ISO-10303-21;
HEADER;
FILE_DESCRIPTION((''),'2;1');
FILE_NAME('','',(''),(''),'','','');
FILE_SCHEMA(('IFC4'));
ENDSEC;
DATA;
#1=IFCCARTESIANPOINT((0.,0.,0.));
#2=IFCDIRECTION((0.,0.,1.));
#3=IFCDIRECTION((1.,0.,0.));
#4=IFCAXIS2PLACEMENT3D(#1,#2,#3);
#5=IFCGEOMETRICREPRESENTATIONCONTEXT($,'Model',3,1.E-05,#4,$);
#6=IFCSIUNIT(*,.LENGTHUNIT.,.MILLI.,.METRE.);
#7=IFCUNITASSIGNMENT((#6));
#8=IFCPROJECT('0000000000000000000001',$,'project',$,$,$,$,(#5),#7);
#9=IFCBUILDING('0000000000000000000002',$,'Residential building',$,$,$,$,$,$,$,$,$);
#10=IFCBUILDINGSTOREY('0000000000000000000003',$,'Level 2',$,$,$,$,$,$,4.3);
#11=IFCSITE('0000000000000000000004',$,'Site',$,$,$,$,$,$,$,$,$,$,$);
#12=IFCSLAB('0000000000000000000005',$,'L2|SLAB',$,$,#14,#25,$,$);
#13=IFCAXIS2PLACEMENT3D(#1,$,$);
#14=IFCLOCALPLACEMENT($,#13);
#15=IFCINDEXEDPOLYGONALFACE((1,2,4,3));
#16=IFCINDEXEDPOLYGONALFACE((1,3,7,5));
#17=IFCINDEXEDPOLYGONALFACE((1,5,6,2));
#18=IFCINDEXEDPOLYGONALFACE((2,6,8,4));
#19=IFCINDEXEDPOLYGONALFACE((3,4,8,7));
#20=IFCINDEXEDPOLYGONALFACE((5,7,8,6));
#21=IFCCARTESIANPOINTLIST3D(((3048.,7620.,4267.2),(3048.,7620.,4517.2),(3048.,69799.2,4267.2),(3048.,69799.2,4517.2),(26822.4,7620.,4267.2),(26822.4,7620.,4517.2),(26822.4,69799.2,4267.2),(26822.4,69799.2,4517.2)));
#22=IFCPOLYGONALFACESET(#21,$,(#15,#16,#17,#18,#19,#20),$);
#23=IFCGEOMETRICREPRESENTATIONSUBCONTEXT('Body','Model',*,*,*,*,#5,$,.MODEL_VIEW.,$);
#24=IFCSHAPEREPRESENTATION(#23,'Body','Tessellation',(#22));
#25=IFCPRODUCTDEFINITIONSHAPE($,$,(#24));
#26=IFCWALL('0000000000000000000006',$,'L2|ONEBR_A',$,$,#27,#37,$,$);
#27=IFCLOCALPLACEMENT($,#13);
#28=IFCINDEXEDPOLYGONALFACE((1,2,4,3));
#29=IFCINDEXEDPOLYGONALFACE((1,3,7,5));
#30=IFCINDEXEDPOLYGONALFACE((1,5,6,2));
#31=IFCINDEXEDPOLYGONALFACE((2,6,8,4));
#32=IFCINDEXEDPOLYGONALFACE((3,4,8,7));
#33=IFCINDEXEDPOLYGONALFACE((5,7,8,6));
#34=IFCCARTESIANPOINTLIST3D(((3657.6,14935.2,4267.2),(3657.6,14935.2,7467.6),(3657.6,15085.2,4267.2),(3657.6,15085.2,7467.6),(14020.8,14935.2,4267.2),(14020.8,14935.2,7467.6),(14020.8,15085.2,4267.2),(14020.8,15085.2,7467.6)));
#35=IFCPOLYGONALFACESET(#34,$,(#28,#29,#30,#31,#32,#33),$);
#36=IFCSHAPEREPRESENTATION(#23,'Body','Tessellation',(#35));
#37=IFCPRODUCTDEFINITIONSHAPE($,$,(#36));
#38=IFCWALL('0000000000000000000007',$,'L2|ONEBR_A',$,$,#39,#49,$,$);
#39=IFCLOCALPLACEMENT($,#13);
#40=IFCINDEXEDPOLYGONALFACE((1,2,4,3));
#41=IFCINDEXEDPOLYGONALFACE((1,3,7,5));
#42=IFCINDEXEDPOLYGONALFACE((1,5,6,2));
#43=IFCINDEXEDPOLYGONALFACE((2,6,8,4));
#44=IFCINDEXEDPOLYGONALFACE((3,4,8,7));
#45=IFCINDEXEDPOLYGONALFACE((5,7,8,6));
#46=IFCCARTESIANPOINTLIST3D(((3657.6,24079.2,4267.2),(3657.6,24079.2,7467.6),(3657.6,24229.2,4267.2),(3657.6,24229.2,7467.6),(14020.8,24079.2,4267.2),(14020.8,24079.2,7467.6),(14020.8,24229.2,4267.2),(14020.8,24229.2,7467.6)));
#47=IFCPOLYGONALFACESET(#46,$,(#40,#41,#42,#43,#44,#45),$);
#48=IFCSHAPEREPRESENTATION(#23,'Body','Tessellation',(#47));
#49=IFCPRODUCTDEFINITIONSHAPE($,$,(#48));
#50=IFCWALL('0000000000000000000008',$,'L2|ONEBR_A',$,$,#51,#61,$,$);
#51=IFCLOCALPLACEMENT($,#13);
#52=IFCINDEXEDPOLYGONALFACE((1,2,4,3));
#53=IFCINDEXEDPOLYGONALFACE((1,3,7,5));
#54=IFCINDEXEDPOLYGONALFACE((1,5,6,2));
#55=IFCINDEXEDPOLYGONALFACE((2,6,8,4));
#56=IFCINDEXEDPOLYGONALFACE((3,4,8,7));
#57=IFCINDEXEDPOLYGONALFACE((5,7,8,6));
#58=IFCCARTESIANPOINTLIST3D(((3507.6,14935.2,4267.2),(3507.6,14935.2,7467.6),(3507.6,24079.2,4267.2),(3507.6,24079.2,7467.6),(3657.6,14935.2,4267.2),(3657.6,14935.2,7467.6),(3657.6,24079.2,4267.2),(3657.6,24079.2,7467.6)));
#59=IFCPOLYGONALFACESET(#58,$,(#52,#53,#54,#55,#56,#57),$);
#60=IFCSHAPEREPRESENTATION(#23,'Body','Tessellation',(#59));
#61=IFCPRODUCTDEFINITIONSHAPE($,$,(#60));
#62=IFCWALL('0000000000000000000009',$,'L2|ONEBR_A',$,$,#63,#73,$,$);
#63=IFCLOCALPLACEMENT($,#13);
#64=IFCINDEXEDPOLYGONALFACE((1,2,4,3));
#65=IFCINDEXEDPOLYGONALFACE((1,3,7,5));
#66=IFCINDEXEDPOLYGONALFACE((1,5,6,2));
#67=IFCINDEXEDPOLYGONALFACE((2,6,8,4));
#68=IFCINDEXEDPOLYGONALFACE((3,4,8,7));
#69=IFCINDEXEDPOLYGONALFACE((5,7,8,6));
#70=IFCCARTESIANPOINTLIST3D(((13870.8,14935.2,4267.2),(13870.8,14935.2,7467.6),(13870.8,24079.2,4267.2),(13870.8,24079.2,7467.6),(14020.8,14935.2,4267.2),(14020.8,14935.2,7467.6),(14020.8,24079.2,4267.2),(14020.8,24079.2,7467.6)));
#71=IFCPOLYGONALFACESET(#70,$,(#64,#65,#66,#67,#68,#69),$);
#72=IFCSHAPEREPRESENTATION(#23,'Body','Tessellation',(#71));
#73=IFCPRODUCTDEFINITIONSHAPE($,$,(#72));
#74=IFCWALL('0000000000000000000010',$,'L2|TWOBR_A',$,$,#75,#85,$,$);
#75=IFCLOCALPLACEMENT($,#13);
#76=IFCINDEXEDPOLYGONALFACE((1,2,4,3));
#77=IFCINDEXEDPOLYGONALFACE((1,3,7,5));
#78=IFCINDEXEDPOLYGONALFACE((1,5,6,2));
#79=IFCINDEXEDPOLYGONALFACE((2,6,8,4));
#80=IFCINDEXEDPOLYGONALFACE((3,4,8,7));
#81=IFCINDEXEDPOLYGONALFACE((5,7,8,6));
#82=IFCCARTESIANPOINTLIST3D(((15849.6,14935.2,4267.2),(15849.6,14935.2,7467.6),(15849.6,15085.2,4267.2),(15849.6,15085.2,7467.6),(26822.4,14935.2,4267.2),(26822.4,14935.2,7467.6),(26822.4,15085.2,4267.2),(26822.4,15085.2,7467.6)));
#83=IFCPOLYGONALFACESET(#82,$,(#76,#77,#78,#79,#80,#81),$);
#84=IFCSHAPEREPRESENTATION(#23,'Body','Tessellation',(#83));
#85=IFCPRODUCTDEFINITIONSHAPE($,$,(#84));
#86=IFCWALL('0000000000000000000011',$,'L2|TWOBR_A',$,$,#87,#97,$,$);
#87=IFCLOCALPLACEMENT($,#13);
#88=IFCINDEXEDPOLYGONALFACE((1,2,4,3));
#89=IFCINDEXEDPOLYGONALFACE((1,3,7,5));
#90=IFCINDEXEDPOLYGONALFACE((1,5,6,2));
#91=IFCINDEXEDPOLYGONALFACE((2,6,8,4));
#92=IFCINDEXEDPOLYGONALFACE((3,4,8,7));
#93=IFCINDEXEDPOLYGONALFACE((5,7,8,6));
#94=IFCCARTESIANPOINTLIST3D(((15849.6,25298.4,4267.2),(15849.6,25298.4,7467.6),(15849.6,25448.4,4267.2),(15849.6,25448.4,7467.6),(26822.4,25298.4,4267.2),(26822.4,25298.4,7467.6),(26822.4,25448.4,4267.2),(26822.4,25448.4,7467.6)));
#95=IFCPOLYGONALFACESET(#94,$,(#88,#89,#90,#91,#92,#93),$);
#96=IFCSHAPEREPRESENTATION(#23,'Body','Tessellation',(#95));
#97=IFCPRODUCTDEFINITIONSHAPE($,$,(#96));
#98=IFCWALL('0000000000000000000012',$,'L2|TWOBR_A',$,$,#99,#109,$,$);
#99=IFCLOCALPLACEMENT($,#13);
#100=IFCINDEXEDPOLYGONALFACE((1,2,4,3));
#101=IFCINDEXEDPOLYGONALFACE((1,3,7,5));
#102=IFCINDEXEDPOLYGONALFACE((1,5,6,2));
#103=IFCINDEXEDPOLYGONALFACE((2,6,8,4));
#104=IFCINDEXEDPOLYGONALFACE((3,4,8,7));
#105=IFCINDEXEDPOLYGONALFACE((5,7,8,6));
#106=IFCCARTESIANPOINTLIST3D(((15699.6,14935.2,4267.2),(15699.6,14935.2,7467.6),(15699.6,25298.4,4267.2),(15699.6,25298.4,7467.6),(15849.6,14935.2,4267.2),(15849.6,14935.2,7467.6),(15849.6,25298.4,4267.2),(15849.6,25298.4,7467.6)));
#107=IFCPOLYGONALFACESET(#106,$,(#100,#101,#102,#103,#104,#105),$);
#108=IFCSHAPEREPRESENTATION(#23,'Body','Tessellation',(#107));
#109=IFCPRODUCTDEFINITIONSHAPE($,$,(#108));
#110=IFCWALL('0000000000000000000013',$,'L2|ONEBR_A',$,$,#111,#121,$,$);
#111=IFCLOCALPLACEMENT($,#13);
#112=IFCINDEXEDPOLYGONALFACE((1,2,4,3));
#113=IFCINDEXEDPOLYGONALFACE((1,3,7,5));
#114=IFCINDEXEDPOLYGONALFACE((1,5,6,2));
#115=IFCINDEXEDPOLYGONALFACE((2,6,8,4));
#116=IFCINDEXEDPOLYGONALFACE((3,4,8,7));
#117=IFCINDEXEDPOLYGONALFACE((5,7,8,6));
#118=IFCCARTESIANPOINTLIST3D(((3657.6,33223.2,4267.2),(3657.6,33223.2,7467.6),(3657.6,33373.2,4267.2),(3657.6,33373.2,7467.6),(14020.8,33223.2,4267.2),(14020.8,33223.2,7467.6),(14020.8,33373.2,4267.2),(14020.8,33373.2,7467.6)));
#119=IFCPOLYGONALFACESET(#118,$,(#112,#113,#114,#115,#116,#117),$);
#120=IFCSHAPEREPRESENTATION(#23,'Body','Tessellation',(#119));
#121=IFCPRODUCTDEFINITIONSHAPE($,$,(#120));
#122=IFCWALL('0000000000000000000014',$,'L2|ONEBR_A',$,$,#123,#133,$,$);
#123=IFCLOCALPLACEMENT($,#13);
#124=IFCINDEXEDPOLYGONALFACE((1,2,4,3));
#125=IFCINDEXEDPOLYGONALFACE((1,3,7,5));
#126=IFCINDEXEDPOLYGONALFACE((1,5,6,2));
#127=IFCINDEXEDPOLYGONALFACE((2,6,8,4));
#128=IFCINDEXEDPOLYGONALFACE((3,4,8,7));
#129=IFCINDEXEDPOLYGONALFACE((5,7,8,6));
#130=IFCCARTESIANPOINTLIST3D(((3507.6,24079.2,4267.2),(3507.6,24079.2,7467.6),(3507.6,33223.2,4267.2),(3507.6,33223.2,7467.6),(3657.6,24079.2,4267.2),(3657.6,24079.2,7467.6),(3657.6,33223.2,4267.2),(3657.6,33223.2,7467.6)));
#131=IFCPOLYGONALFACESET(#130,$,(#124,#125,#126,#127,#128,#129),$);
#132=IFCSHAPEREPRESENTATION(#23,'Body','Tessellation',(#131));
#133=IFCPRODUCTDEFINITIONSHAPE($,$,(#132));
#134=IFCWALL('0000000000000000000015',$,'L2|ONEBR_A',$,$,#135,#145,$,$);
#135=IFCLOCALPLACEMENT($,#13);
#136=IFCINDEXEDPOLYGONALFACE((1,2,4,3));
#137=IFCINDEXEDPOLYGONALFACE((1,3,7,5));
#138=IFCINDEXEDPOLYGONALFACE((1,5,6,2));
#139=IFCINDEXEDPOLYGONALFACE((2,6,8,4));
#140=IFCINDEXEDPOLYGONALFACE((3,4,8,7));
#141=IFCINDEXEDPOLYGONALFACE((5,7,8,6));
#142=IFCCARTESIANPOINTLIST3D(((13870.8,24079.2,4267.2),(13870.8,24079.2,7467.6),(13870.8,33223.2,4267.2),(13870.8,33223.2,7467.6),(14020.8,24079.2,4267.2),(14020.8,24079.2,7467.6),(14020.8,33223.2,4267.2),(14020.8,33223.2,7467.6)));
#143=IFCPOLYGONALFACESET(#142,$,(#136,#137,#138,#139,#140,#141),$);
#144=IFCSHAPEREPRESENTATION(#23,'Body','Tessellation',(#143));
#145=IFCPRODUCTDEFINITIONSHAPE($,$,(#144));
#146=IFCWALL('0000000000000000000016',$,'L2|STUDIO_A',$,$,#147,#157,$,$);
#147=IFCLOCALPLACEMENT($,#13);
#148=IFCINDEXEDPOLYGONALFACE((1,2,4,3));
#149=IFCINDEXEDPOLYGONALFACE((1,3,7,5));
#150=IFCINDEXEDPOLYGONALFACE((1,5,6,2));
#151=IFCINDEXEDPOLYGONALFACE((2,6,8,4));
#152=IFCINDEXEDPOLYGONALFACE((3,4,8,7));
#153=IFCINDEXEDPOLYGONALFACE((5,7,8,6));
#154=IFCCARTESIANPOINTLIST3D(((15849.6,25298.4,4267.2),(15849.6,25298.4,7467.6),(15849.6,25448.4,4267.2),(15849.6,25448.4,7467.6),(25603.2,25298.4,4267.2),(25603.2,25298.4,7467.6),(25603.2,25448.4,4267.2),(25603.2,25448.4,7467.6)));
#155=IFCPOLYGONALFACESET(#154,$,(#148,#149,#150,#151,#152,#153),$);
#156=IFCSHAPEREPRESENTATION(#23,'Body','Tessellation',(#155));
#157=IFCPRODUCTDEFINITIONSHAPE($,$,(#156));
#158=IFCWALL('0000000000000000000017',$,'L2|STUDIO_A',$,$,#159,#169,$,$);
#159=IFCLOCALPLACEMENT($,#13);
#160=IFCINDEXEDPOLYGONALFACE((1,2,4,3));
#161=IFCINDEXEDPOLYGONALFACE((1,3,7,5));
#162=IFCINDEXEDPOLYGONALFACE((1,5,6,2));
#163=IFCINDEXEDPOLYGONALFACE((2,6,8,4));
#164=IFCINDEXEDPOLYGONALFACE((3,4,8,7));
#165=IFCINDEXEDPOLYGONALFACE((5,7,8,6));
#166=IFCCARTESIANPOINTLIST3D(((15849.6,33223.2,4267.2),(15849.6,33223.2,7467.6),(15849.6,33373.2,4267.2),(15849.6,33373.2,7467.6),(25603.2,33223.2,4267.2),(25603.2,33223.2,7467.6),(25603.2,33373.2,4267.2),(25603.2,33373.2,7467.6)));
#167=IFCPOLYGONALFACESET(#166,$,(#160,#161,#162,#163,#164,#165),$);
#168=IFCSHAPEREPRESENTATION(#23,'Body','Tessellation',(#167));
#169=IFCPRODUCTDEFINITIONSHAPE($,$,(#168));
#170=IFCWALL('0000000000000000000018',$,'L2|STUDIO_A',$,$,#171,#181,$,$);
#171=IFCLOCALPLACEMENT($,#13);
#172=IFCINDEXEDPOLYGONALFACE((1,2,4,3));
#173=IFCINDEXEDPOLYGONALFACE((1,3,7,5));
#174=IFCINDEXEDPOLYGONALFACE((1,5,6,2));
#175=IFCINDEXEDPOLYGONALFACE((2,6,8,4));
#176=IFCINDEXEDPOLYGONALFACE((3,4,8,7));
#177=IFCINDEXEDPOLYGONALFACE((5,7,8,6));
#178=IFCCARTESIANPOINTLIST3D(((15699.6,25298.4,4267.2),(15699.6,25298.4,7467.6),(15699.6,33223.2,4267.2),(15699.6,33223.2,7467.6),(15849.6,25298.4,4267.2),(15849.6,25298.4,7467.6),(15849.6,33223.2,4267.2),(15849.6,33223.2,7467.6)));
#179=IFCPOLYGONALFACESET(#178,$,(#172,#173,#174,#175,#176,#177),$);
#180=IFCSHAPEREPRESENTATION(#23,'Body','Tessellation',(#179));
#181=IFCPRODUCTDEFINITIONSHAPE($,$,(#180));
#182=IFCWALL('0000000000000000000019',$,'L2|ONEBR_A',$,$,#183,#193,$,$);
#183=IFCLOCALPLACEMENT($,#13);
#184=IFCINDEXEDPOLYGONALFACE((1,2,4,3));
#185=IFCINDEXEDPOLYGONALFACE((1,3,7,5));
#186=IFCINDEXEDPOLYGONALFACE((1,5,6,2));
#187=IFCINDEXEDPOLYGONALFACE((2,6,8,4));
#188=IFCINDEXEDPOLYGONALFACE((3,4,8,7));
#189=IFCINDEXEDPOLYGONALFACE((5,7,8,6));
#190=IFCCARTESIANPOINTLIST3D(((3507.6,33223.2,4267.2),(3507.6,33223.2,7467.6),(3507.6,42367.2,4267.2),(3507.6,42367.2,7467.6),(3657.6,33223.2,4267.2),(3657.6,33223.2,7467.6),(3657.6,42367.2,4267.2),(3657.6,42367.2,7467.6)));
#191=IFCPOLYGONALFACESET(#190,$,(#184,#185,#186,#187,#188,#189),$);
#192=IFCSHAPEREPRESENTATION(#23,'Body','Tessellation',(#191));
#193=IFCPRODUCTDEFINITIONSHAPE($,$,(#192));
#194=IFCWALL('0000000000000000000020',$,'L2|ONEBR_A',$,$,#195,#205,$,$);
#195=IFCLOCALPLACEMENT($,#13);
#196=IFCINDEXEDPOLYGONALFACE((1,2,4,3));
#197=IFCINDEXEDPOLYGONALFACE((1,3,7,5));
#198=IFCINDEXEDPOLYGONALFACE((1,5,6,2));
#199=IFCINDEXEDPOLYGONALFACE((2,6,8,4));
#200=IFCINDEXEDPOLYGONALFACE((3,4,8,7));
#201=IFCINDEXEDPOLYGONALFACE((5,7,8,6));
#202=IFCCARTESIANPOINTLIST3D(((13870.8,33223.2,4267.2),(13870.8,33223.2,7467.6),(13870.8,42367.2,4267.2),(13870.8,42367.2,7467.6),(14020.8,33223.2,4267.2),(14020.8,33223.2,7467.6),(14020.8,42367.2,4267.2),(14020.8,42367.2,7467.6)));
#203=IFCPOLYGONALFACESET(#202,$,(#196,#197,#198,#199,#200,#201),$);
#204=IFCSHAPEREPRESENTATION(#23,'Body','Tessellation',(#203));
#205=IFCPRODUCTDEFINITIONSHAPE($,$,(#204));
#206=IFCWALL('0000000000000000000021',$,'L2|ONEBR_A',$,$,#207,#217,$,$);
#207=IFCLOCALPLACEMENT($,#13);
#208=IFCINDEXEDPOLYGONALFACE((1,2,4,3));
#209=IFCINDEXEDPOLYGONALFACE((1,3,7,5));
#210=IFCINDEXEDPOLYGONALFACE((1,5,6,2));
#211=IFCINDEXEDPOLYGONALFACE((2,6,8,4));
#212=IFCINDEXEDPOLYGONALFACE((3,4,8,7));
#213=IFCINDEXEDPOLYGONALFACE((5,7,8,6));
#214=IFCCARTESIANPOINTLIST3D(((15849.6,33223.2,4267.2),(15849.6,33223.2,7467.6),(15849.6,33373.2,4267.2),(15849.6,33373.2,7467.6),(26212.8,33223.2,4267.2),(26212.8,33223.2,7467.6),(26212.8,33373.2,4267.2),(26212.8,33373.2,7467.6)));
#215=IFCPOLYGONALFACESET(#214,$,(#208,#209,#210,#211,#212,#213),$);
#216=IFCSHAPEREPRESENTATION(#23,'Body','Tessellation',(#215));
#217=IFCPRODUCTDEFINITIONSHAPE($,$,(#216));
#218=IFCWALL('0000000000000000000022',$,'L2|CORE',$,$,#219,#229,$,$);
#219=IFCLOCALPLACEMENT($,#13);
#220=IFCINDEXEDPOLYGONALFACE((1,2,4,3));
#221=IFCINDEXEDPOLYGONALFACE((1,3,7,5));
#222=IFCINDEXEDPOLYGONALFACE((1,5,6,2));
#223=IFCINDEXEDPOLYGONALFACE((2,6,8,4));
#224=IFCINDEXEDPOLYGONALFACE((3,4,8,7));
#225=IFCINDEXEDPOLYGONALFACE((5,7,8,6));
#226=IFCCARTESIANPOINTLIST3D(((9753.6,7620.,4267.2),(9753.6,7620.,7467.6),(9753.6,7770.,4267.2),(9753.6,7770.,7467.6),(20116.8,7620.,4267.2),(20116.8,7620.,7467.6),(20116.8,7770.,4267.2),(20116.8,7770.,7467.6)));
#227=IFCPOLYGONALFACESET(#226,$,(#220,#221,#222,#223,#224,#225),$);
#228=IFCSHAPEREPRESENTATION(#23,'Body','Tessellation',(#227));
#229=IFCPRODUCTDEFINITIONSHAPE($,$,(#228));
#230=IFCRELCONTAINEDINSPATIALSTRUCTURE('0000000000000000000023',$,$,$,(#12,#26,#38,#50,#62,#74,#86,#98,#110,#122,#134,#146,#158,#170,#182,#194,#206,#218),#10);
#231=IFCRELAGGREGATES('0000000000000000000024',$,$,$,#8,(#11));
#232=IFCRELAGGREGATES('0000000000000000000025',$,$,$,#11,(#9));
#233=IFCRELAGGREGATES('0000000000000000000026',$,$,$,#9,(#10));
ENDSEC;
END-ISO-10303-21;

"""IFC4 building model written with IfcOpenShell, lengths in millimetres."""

from ifc_helpers import new_model, si_unit, frame, origin_with_axes, place, context, subcontext, project, spatial, indexed_curve, outline, extrude, element, save


model = new_model("IFC4")

# Units and contexts
model_context = context("Model", 3, precision=1e-05, world=origin_with_axes())
body_context = subcontext(model_context, "Body", "Model", "MODEL_VIEW")
ifc_project = project(units=[si_unit("LENGTHUNIT", "METRE", prefix="MILLI")], contexts=[model_context])

# Site, building, storey
site = spatial("IfcSite", under=ifc_project, Name="Site")
building = spatial("IfcBuilding", under=site, Name="Residential building")
storey = spatial("IfcBuildingStorey", under=building, Name="Level 2", Elevation=4.3)

# Slab
slab_placement = place(None, frame((3048.0, 7620.0, 4267.2), z_axis=(0.0, 0.0, 1.0), x_axis=(1.0, 0.0, 0.0)))
element("IfcSlab", 1, at=slab_placement, inside=storey, Name="L2|SLAB", context=body_context, shape_type="SweptSolid", body=[
    extrude(outline(indexed_curve([(0.0, 0.0), (23774.4, 0.0), (23774.4, 62179.2), (0.0, 62179.2), (0.0, 0.0)])), None, (0.0, 0.0, 1.0), 250.0),
])

# Walls
for number, where, z_axis, x_axis, name in (
    (2, (3657.6, 14935.2, 4267.2), (0.0, 0.0, 1.0), (1.0, 0.0, 0.0), "L2|ONEBR_A"),
    (3, (3657.6, 24079.2, 4267.2), (0.0, 0.0, 1.0), (1.0, 0.0, 0.0), "L2|ONEBR_A"),
):
    element("IfcWall", number, at=place(None, frame(where, z_axis=z_axis, x_axis=x_axis)), inside=storey, Name=name, context=body_context, shape_type="SweptSolid", body=[
        extrude(outline(indexed_curve([(0.0, 0.0), (0.0, 150.0), (10363.2, 150.0), (10363.2, 0.0), (0.0, 0.0)], self_intersect=False)), origin_with_axes(), (0.0, 0.0, 1.0), 3200.4),
    ])
for number, where, z_axis, x_axis, name in (
    (4, (3657.6, 14935.2, 4267.2), (0.0, 0.0, 1.0), (0.0, 1.0, 0.0), "L2|ONEBR_A"),
    (5, (14020.8, 14935.2, 4267.2), (0.0, 0.0, 1.0), (0.0, 1.0, 0.0), "L2|ONEBR_A"),
):
    element("IfcWall", number, at=place(None, frame(where, z_axis=z_axis, x_axis=x_axis)), inside=storey, Name=name, context=body_context, shape_type="SweptSolid", body=[
        extrude(outline(indexed_curve([(0.0, 0.0), (0.0, 150.0), (9144.0, 150.0), (9144.0, 0.0), (0.0, 0.0)], self_intersect=False)), origin_with_axes(), (0.0, 0.0, 1.0), 3200.4),
    ])
for number, where, z_axis, x_axis, name in (
    (6, (15849.6, 14935.2, 4267.2), (0.0, 0.0, 1.0), (1.0, 0.0, 0.0), "L2|TWOBR_A"),
    (7, (15849.6, 25298.4, 4267.2), (0.0, 0.0, 1.0), (1.0, 0.0, 0.0), "L2|TWOBR_A"),
):
    element("IfcWall", number, at=place(None, frame(where, z_axis=z_axis, x_axis=x_axis)), inside=storey, Name=name, context=body_context, shape_type="SweptSolid", body=[
        extrude(outline(indexed_curve([(0.0, 0.0), (0.0, 150.0), (10972.8, 150.0), (10972.8, 0.0), (0.0, 0.0)], self_intersect=False)), origin_with_axes(), (0.0, 0.0, 1.0), 3200.4),
    ])
for number, where, z_axis, x_axis, name in (
    (8, (15849.6, 14935.2, 4267.2), (0.0, 0.0, 1.0), (0.0, 1.0, 0.0), "L2|TWOBR_A"),
    (9, (3657.6, 33223.2, 4267.2), (0.0, 0.0, 1.0), (1.0, 0.0, 0.0), "L2|ONEBR_A"),
):
    element("IfcWall", number, at=place(None, frame(where, z_axis=z_axis, x_axis=x_axis)), inside=storey, Name=name, context=body_context, shape_type="SweptSolid", body=[
        extrude(outline(indexed_curve([(0.0, 0.0), (0.0, 150.0), (10363.2, 150.0), (10363.2, 0.0), (0.0, 0.0)], self_intersect=False)), origin_with_axes(), (0.0, 0.0, 1.0), 3200.4),
    ])
for number, where, z_axis, x_axis, name in (
    (10, (3657.6, 24079.2, 4267.2), (0.0, 0.0, 1.0), (0.0, 1.0, 0.0), "L2|ONEBR_A"),
    (11, (14020.8, 24079.2, 4267.2), (0.0, 0.0, 1.0), (0.0, 1.0, 0.0), "L2|ONEBR_A"),
):
    element("IfcWall", number, at=place(None, frame(where, z_axis=z_axis, x_axis=x_axis)), inside=storey, Name=name, context=body_context, shape_type="SweptSolid", body=[
        extrude(outline(indexed_curve([(0.0, 0.0), (0.0, 150.0), (9144.0, 150.0), (9144.0, 0.0), (0.0, 0.0)], self_intersect=False)), origin_with_axes(), (0.0, 0.0, 1.0), 3200.4),
    ])
for number, where, z_axis, x_axis, name in (
    (12, (15849.6, 25298.4, 4267.2), (0.0, 0.0, 1.0), (1.0, 0.0, 0.0), "L2|STUDIO_A"),
    (13, (15849.6, 33223.2, 4267.2), (0.0, 0.0, 1.0), (1.0, 0.0, 0.0), "L2|STUDIO_A"),
):
    element("IfcWall", number, at=place(None, frame(where, z_axis=z_axis, x_axis=x_axis)), inside=storey, Name=name, context=body_context, shape_type="SweptSolid", body=[
        extrude(outline(indexed_curve([(0.0, 0.0), (0.0, 150.0), (9753.6, 150.0), (9753.6, 0.0), (0.0, 0.0)], self_intersect=False)), origin_with_axes(), (0.0, 0.0, 1.0), 3200.4),
    ])
wall_1_placement = place(None, frame((15849.6, 25298.4, 4267.2), z_axis=(0.0, 0.0, 1.0), x_axis=(0.0, 1.0, 0.0)))
element("IfcWall", 14, at=wall_1_placement, inside=storey, Name="L2|STUDIO_A", context=body_context, shape_type="SweptSolid", body=[
    extrude(outline(indexed_curve([(0.0, 0.0), (0.0, 150.0), (7924.8, 150.0), (7924.8, 0.0), (0.0, 0.0)], self_intersect=False)), origin_with_axes(), (0.0, 0.0, 1.0), 3200.4),
])
for number, where, z_axis, x_axis, name in (
    (15, (3657.6, 33223.2, 4267.2), (0.0, 0.0, 1.0), (0.0, 1.0, 0.0), "L2|ONEBR_A"),
    (16, (14020.8, 33223.2, 4267.2), (0.0, 0.0, 1.0), (0.0, 1.0, 0.0), "L2|ONEBR_A"),
):
    element("IfcWall", number, at=place(None, frame(where, z_axis=z_axis, x_axis=x_axis)), inside=storey, Name=name, context=body_context, shape_type="SweptSolid", body=[
        extrude(outline(indexed_curve([(0.0, 0.0), (0.0, 150.0), (9144.0, 150.0), (9144.0, 0.0), (0.0, 0.0)], self_intersect=False)), origin_with_axes(), (0.0, 0.0, 1.0), 3200.4),
    ])
for number, where, z_axis, x_axis, name in (
    (17, (15849.6, 33223.2, 4267.2), (0.0, 0.0, 1.0), (1.0, 0.0, 0.0), "L2|ONEBR_A"),
    (18, (9753.6, 7620.0, 4267.2), (0.0, 0.0, 1.0), (1.0, 0.0, 0.0), "L2|CORE"),
):
    element("IfcWall", number, at=place(None, frame(where, z_axis=z_axis, x_axis=x_axis)), inside=storey, Name=name, context=body_context, shape_type="SweptSolid", body=[
        extrude(outline(indexed_curve([(0.0, 0.0), (0.0, 150.0), (10363.2, 150.0), (10363.2, 0.0), (0.0, 0.0)], self_intersect=False)), origin_with_axes(), (0.0, 0.0, 1.0), 3200.4),
    ])

save(model, "model.ifc")
